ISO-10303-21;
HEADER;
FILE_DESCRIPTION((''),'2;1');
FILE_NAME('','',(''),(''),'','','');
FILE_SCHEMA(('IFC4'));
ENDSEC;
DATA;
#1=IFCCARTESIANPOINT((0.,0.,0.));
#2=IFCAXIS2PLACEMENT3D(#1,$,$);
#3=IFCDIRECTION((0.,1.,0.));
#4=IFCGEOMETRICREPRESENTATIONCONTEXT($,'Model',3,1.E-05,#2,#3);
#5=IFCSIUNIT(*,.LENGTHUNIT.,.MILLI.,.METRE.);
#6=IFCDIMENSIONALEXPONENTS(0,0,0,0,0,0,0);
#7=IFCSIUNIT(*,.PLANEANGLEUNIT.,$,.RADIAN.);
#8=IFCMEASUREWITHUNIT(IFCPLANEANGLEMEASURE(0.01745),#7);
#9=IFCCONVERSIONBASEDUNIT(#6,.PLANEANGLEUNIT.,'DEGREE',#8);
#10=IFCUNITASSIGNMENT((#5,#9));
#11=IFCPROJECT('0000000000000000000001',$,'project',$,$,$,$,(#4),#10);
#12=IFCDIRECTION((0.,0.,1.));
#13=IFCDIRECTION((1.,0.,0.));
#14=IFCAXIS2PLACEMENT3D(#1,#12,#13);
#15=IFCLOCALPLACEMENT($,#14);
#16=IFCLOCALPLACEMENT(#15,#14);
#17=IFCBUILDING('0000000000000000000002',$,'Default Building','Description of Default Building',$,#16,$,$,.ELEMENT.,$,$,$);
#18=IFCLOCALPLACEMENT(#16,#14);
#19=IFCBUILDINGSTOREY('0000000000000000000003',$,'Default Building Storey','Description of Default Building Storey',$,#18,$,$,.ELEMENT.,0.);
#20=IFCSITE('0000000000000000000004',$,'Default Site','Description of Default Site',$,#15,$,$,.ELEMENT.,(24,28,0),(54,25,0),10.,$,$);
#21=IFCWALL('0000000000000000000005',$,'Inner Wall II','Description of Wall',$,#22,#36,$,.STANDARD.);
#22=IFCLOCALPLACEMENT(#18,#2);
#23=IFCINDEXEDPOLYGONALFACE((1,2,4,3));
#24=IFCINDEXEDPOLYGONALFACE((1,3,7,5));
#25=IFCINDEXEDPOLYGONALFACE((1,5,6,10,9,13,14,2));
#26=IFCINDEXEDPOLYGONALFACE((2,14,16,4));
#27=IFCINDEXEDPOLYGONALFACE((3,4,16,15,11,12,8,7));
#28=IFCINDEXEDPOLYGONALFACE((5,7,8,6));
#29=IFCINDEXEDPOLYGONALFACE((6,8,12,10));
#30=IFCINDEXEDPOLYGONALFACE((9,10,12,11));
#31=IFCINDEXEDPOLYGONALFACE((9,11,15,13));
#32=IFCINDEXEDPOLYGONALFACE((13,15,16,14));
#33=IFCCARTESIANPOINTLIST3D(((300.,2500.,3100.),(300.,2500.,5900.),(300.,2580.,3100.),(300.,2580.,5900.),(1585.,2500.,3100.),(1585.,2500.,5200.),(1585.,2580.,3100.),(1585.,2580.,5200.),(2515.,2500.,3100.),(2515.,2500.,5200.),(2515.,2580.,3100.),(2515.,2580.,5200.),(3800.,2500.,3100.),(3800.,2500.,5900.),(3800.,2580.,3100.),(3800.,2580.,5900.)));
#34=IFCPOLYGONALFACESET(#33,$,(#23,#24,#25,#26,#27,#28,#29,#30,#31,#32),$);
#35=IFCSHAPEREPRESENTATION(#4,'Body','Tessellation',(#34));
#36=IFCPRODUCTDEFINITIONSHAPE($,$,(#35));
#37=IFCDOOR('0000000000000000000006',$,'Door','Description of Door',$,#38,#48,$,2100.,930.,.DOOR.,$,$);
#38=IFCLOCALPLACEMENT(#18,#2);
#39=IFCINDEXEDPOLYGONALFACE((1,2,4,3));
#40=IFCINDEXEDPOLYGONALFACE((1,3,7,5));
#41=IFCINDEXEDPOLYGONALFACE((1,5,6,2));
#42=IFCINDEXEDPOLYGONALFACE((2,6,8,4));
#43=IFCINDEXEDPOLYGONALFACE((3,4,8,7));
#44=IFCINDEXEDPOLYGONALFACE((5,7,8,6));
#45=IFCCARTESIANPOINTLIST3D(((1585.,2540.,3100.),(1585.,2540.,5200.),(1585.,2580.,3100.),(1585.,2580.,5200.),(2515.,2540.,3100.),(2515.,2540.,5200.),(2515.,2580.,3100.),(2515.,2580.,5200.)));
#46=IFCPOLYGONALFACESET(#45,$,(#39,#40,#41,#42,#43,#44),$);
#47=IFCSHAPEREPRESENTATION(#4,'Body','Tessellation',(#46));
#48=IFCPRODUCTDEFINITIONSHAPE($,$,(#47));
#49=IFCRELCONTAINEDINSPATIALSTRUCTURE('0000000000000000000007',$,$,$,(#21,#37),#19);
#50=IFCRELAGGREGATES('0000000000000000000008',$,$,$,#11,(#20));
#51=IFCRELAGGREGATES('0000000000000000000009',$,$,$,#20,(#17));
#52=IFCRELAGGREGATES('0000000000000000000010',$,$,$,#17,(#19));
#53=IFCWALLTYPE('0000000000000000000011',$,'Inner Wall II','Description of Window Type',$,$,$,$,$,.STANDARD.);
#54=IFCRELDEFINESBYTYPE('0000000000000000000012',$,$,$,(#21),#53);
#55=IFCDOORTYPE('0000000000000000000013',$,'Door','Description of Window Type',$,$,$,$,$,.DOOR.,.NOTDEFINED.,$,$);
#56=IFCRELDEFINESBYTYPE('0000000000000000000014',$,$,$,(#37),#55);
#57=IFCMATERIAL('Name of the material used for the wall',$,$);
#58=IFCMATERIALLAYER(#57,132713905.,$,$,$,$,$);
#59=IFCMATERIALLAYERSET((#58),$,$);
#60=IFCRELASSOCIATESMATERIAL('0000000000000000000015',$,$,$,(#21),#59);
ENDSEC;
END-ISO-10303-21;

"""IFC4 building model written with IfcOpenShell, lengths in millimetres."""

from ifc_helpers import new_model, entity, si_unit, converted_unit, direction, frame, origin, origin_with_axes, place, context, project, spatial, polyline, outline, extrude, material, layer, layer_set, layer_usage, type_object, element, fill, save


model = new_model("IFC4")

# Units and contexts
model_context = context("Model", 3, precision=1e-05, world=origin(), true_north=direction((0.0, 1.0, 0.0)))
ifc_project = project(units=[si_unit("LENGTHUNIT", "METRE", prefix="MILLI"), converted_unit("PLANEANGLEUNIT", "DEGREE", entity("IfcPlaneAngleMeasure", 0.01745), si_unit("PLANEANGLEUNIT", "RADIAN"), dimensions=[0, 0, 0, 0, 0, 0, 0])], contexts=[model_context])

# Site, building, storey
site_placement = place(None, origin_with_axes())
site = spatial("IfcSite", under=ifc_project, at=site_placement, Name="Default Site", Description="Description of Default Site", CompositionType="ELEMENT", RefLatitude=(24, 28, 0), RefLongitude=(54, 25, 0), RefElevation=10.0)
building_placement = place(site_placement, origin_with_axes())
building = spatial("IfcBuilding", under=site, at=building_placement, Name="Default Building", Description="Description of Default Building", CompositionType="ELEMENT")
storey_placement = place(building_placement, origin_with_axes())
storey = spatial("IfcBuildingStorey", under=building, at=storey_placement, Name="Default Building Storey", Description="Description of Default Building Storey", CompositionType="ELEMENT", Elevation=0.0)

# Wall, opening, door
ifc_material_1 = material(Name="Name of the material used for the wall")
ifc_layer_1 = layer(ifc_material_1, 132713905.0)
ifc_layer_set_1 = layer_set([ifc_layer_1])
ifc_layer_usage_1 = layer_usage(ifc_layer_set_1, "AXIS2", "POSITIVE", -66356952.5)
wall_type_1 = type_object("IfcWallType", Name="Inner Wall II", Description="Description of Window Type", PredefinedType="STANDARD")
wall_1_placement = place(storey_placement, frame((3800.0, 2540.0, 3100.0), z_axis=(0.0, 0.0, 1.0), x_axis=(-1.0, 0.0, 0.0)))
wall_1 = element("IfcWall", 1, at=wall_1_placement, inside=storey, type_object=wall_type_1, material=ifc_layer_usage_1, Name="Inner Wall II", Description="Description of Wall", PredefinedType="STANDARD", context=model_context, shape_type="SweptSolid", body=[
    extrude(outline(polyline([(0.0, -40.0), (0.0, 40.0), (3500.0, 40.0), (3500.0, -40.0), (0.0, -40.0)])), origin_with_axes(), (0.0, 0.0, 1.0), 2800.0),
])
opening_1_placement = place(wall_1_placement, frame((1285.0, -40.0, 0.0), z_axis=(0.0, 0.0, 1.0), x_axis=(1.0, 0.0, 0.0)))
opening_1 = element("IfcOpeningElement", 2, at=opening_1_placement, cuts=wall_1, context=model_context, shape_type="SweptSolid", body=[
    extrude(outline(polyline([(0.0, 0.0), (0.0, 80.0), (930.0, 80.0), (930.0, 0.0), (0.0, 0.0)])), origin_with_axes(), (0.0, 0.0, 1.0), 2100.0),
])
door_type_1 = type_object("IfcDoorType", Name="Door", Description="Description of Window Type", PredefinedType="DOOR")
door_1_placement = place(opening_1_placement, origin_with_axes())
door_1 = element("IfcDoor", 3, at=door_1_placement, inside=storey, type_object=door_type_1, Name="Door", Description="Description of Door", OverallHeight=2100.0, OverallWidth=930.0, PredefinedType="DOOR", context=model_context, shape_type="SweptSolid", body=[
    extrude(outline(polyline([(0.0, 0.0), (0.0, 40.0), (930.0, 40.0), (930.0, 0.0), (0.0, 0.0)])), origin_with_axes(), (0.0, 0.0, 1.0), 2100.0),
])
fill(opening_1, door_1)

save(model, "model.ifc")
